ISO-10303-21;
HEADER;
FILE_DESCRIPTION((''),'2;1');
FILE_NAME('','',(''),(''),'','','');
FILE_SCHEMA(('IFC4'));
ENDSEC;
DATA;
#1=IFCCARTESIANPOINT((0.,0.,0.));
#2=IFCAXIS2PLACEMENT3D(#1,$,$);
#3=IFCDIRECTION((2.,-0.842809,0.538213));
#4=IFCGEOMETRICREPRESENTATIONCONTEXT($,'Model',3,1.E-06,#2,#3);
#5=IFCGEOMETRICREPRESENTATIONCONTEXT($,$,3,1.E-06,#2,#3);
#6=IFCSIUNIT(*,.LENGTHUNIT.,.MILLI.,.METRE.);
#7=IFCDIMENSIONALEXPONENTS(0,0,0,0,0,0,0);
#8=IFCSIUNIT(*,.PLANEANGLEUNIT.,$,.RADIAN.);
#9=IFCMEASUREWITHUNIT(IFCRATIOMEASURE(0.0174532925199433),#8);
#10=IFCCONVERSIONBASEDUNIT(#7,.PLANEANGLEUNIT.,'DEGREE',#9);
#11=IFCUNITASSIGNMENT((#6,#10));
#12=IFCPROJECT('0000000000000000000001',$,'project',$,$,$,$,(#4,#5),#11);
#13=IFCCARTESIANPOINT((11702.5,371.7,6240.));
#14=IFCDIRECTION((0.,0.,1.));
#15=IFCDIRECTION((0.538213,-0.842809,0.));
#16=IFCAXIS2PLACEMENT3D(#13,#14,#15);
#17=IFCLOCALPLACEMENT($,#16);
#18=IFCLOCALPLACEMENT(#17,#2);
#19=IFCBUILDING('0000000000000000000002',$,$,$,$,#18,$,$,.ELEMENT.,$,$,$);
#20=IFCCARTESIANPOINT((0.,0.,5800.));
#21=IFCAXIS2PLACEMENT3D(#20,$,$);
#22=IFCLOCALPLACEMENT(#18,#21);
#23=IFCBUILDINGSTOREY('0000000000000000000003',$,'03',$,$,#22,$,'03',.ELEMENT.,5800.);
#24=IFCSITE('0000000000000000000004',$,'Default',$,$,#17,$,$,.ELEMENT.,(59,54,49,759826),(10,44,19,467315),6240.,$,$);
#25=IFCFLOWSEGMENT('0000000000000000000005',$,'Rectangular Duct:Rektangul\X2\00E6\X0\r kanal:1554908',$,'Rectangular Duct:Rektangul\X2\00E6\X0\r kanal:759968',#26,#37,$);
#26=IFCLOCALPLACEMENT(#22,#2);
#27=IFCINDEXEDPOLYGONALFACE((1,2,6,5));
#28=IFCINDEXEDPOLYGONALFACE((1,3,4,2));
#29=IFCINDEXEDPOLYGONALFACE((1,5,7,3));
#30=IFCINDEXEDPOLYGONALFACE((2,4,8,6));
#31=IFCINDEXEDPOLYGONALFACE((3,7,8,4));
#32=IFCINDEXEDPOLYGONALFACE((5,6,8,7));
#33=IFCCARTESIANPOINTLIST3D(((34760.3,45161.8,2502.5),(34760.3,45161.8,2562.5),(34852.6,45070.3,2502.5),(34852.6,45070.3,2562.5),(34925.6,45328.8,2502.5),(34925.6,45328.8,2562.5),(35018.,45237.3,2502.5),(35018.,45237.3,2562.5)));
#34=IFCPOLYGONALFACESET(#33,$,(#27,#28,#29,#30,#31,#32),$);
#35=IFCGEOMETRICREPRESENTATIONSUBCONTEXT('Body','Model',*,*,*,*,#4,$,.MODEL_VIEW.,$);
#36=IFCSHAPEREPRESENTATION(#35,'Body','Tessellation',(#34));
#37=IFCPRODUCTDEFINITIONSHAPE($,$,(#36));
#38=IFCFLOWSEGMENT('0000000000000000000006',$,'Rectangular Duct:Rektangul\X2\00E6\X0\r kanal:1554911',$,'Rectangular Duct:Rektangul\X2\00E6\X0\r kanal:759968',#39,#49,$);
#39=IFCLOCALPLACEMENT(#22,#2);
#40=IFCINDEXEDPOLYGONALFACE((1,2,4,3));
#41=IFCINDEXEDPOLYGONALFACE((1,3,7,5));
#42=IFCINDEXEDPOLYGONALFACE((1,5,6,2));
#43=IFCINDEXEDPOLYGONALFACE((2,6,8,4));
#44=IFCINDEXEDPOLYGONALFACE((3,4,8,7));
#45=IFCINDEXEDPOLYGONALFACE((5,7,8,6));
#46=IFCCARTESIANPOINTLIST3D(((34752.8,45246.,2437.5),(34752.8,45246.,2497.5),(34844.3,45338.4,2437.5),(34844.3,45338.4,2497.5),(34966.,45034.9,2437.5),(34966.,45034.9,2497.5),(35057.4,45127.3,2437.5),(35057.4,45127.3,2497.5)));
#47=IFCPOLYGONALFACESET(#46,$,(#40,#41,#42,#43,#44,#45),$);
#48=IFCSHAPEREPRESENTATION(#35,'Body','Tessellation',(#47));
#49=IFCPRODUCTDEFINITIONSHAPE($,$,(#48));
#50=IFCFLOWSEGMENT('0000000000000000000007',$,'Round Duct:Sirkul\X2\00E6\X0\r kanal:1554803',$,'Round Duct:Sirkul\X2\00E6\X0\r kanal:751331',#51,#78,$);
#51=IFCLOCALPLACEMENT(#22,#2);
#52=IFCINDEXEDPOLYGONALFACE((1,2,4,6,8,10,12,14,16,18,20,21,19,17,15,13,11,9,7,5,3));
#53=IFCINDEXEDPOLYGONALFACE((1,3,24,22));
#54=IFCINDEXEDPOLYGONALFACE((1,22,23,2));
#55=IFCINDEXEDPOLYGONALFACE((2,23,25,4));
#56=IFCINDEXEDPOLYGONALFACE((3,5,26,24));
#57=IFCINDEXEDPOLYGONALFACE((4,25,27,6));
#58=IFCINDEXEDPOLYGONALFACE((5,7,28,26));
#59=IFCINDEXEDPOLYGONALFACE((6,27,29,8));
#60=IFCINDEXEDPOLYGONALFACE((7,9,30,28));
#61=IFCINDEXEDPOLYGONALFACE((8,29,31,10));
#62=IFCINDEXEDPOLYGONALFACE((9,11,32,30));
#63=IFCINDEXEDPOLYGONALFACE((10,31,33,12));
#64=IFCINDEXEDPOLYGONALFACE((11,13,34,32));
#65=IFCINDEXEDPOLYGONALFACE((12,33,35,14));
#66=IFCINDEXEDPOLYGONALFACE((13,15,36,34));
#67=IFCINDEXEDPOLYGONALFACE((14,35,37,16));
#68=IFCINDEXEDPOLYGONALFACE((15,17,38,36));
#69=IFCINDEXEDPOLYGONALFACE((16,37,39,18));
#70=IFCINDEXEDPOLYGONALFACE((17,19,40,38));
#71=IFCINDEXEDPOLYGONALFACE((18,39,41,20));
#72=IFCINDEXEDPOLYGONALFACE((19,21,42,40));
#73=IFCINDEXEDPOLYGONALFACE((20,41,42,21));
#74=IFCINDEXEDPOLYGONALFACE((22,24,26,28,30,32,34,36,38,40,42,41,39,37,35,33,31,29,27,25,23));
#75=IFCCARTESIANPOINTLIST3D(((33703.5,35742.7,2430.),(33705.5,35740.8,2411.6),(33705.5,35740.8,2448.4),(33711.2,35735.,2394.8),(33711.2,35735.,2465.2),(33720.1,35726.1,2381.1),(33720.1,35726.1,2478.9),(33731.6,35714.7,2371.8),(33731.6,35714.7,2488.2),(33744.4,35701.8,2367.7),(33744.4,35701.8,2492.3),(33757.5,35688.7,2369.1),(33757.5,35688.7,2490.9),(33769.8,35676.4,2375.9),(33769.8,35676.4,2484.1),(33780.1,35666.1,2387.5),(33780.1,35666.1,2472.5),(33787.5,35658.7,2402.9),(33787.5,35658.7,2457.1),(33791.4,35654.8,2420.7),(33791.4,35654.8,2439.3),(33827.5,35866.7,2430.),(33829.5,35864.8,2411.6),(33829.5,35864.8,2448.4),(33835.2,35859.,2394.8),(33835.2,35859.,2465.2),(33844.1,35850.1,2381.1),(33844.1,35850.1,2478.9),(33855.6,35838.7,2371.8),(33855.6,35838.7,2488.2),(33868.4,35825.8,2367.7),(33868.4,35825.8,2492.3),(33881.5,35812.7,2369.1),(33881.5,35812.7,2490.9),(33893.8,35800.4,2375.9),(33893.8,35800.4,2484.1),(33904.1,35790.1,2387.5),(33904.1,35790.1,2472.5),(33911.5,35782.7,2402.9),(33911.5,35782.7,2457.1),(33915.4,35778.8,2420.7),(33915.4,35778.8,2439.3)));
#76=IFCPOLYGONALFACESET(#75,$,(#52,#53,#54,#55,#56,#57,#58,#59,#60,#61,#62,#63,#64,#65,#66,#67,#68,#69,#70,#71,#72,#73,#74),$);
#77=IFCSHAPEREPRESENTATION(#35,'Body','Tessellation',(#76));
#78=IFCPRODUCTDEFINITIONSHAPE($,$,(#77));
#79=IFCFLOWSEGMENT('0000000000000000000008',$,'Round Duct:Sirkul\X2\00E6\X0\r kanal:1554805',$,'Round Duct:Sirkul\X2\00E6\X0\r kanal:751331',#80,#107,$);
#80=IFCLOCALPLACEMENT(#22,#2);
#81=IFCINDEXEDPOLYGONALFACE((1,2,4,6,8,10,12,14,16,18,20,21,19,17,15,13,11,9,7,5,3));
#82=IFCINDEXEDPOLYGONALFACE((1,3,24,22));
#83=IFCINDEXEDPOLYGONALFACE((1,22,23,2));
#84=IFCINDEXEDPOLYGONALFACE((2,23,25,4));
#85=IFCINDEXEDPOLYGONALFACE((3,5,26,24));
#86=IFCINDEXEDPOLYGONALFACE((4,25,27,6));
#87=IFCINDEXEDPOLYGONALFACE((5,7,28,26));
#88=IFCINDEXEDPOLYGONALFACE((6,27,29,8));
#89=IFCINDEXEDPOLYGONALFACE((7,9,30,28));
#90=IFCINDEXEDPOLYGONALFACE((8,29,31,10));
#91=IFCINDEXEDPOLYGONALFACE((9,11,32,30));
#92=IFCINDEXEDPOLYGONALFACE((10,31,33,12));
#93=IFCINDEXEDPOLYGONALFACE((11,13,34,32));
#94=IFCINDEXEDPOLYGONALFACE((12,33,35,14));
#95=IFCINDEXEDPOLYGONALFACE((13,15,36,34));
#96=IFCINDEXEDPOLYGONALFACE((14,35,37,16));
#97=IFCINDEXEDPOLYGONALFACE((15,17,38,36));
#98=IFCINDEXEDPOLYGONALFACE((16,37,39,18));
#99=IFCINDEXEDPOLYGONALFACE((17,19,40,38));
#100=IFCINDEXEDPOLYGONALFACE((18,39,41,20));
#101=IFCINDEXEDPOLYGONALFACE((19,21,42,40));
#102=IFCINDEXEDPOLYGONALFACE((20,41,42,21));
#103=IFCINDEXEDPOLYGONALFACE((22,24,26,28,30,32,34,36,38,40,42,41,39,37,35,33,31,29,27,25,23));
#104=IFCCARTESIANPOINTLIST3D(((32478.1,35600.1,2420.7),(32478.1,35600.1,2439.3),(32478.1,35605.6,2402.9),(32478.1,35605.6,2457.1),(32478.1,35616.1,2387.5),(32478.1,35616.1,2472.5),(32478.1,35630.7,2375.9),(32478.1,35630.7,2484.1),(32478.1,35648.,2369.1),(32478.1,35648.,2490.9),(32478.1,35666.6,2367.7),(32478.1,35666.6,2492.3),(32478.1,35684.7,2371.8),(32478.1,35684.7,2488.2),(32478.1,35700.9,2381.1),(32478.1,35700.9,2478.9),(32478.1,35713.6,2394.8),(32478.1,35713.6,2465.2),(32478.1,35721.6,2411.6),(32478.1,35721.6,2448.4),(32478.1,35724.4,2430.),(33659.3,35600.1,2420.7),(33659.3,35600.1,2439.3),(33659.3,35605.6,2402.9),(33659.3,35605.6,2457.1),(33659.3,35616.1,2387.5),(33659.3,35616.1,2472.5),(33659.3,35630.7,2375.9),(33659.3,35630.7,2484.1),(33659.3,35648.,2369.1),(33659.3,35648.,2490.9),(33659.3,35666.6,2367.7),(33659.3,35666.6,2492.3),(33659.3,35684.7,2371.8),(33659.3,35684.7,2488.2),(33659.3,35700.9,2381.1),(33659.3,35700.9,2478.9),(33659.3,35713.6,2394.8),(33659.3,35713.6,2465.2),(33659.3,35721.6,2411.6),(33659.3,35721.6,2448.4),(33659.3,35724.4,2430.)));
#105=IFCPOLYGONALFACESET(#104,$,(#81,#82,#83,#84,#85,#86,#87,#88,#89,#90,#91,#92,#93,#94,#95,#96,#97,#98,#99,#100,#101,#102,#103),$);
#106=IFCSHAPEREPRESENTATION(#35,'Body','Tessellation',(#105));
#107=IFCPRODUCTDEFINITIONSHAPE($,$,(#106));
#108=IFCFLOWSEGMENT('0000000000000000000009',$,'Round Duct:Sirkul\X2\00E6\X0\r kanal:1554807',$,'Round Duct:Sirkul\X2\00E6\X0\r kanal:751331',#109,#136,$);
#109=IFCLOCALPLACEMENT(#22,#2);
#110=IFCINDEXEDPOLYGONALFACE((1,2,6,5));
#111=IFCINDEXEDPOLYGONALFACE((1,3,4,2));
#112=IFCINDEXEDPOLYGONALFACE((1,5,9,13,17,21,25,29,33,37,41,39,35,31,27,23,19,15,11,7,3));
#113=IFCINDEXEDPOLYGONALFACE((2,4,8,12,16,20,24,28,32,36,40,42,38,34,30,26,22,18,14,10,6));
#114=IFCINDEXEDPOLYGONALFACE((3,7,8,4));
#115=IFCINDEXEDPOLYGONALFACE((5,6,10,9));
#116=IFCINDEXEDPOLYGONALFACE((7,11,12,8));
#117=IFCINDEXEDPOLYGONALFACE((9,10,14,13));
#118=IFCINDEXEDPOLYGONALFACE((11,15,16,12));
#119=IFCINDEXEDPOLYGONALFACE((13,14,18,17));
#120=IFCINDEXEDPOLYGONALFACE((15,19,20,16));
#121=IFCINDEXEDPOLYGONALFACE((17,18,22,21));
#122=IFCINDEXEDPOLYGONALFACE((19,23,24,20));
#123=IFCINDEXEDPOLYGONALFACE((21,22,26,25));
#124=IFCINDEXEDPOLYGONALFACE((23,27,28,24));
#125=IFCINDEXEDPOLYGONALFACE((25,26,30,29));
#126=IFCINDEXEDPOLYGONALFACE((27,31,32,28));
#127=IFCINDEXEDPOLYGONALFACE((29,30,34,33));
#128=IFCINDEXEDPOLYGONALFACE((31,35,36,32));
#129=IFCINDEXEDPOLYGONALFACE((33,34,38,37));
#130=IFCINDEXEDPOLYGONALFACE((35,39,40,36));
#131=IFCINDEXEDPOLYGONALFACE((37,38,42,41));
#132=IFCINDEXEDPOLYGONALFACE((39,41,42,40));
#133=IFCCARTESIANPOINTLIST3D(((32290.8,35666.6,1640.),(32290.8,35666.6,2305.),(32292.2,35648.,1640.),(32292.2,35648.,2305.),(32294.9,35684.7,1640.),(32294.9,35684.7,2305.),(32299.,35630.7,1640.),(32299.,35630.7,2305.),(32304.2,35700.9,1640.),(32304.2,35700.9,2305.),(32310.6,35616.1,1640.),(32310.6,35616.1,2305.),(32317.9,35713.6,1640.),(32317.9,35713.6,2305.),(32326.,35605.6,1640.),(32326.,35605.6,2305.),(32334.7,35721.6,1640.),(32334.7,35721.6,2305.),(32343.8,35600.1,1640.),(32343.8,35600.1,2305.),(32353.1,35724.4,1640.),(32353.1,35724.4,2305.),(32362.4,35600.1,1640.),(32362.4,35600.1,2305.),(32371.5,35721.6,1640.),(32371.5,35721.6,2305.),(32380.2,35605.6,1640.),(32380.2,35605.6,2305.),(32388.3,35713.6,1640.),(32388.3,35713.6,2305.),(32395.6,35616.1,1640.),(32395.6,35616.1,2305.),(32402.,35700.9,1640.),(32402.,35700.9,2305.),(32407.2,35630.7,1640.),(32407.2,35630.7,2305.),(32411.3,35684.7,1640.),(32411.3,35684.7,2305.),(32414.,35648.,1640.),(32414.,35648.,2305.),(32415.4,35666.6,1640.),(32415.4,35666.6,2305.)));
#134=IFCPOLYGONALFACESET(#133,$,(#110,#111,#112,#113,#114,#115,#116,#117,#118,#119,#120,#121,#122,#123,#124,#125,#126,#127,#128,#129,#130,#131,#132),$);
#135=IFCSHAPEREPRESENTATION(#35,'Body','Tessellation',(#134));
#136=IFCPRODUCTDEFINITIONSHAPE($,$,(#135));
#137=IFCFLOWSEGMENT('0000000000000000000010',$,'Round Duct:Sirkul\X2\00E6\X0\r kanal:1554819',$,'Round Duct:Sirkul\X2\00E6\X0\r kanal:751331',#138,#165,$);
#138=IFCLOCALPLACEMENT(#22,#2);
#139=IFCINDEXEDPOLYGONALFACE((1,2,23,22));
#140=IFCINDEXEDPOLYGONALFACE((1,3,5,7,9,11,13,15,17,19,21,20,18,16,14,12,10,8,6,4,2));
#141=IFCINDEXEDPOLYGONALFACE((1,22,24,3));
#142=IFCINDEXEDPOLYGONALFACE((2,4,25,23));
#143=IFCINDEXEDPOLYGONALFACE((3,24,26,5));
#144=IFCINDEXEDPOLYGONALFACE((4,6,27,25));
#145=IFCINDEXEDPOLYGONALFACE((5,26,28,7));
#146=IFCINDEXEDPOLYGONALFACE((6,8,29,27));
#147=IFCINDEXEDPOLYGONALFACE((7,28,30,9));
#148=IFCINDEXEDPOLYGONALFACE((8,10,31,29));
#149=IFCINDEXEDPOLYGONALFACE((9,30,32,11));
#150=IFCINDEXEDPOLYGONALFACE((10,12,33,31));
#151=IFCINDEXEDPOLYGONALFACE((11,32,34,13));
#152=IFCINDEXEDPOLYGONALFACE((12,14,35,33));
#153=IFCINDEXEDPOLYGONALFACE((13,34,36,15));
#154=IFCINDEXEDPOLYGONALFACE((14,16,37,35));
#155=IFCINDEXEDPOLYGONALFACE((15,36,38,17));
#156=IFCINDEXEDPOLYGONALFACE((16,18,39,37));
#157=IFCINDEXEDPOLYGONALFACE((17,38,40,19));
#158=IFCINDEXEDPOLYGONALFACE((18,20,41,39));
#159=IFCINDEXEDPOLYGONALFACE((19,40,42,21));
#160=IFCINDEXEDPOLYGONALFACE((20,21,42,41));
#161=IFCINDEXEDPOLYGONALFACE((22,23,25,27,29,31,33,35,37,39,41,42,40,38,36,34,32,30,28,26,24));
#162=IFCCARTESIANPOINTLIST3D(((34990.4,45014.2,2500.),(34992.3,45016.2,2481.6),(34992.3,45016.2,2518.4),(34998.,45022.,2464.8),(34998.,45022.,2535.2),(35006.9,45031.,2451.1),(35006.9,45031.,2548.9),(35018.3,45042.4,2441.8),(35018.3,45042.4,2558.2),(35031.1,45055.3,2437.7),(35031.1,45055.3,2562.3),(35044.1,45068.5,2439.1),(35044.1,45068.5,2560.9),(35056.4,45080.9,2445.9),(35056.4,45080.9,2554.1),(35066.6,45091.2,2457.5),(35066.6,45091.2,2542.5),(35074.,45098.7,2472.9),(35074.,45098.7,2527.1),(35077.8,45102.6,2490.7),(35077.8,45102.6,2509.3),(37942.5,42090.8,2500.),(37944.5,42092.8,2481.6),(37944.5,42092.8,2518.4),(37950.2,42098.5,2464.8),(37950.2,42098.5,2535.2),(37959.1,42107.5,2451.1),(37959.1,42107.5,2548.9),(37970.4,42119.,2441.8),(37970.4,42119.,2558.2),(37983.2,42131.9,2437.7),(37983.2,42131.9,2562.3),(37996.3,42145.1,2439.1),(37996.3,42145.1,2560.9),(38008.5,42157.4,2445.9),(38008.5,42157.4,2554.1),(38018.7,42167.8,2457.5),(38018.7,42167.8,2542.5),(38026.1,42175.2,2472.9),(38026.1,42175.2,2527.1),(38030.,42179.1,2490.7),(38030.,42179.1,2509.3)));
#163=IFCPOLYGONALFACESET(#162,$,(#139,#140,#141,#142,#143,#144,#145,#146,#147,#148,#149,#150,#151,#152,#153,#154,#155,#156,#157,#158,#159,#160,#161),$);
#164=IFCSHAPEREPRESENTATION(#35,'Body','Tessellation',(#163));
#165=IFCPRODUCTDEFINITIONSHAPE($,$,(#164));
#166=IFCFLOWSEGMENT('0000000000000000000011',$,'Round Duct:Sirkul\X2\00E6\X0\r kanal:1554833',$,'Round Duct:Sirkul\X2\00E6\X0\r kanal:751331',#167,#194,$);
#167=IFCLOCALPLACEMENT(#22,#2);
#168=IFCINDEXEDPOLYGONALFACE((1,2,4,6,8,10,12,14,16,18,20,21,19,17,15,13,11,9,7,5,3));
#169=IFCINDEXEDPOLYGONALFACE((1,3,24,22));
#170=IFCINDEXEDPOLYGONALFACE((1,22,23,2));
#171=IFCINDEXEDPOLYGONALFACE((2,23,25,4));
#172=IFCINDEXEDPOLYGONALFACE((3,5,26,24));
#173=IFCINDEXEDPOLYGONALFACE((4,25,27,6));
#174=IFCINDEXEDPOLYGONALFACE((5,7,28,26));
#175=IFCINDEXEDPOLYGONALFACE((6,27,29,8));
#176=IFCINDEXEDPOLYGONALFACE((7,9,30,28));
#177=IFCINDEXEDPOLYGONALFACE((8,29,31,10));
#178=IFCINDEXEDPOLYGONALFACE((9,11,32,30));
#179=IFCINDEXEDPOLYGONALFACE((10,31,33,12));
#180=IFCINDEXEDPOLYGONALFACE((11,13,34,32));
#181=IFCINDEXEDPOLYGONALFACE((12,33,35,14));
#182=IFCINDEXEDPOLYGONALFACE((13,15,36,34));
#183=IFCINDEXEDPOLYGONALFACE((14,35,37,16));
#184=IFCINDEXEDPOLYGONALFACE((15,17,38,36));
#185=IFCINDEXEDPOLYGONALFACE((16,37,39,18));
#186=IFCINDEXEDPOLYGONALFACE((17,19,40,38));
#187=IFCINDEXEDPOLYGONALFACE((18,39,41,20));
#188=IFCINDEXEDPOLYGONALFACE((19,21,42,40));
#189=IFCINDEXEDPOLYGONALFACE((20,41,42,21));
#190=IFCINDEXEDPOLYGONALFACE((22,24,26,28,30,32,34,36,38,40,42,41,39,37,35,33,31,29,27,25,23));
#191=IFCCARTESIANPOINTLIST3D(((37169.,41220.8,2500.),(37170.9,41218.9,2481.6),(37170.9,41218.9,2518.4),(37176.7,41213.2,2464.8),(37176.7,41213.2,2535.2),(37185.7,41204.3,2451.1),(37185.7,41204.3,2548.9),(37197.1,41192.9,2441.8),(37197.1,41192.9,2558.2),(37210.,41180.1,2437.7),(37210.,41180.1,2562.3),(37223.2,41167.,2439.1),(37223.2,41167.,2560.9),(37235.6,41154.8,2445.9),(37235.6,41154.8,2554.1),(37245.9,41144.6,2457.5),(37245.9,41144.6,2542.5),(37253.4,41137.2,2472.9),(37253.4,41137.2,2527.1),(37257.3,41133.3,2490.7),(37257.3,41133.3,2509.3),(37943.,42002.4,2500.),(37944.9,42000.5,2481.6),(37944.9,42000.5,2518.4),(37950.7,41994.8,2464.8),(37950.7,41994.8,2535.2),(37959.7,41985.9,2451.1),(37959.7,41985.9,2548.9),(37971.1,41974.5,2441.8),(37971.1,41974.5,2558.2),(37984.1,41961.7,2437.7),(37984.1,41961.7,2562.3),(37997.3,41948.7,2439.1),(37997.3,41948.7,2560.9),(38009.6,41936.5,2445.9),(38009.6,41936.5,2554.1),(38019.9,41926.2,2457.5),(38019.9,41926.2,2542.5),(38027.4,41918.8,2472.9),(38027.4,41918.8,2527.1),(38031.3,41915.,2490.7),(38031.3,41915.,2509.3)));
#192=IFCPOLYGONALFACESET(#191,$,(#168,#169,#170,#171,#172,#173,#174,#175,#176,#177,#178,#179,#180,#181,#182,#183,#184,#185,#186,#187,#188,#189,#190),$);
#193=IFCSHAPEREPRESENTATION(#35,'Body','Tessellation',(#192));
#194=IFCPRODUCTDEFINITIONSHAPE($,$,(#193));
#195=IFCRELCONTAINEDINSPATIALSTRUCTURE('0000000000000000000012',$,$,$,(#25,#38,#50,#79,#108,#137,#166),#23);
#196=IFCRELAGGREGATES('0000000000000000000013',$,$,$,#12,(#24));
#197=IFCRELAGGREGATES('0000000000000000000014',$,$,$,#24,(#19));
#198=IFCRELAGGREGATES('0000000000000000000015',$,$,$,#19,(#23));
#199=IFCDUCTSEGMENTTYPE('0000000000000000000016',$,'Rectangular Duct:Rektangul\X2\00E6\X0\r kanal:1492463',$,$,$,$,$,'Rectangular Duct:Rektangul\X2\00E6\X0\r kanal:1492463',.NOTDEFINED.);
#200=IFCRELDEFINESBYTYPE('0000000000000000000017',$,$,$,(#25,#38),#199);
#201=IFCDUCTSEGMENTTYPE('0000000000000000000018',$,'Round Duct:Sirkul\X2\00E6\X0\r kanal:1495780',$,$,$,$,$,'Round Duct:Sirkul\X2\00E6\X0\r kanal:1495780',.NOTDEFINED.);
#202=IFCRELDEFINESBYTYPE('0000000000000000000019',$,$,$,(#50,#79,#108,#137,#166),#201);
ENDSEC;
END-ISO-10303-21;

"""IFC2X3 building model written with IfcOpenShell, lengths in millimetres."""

from ifc_helpers import new_model, entity, si_unit, converted_unit, direction, frame, frame_2d, origin, origin_2d_with_axis, place, context, subcontext, project, spatial, rectangle, circle, extrude, type_object, element, save


model = new_model("IFC2X3")

# Units and contexts
model_context = context("Model", 3, precision=1e-06, world=origin(), true_north=direction((2.0, -0.842809, 0.538213)))
context_of_model = context(None, 3, precision=1e-06, world=origin(), true_north=direction((2.0, -0.842809, 0.538213)))
body_context = subcontext(model_context, "Body", "Model", "MODEL_VIEW")
ifc_project = project(units=[si_unit("LENGTHUNIT", "METRE", prefix="MILLI"), converted_unit("PLANEANGLEUNIT", "DEGREE", entity("IfcRatioMeasure", 0.0174532925199433), si_unit("PLANEANGLEUNIT", "RADIAN"), dimensions=[0, 0, 0, 0, 0, 0, 0])], contexts=[model_context, context_of_model])

# Site, building, storey
site_placement = place(None, frame((11702.5, 371.7, 6240.0), z_axis=(0.0, 0.0, 1.0), x_axis=(0.538213, -0.842809, 0.0)))
site = spatial("IfcSite", under=ifc_project, at=site_placement, Name="Default", CompositionType="ELEMENT", RefLatitude=(59, 54, 49, 759826), RefLongitude=(10, 44, 19, 467315), RefElevation=6240.0)
building_placement = place(site_placement, origin())
building = spatial("IfcBuilding", under=site, at=building_placement, CompositionType="ELEMENT")
storey_placement = place(building_placement, frame((0.0, 0.0, 5800.0)))
storey = spatial("IfcBuildingStorey", under=building, at=storey_placement, Name="03", LongName="03", CompositionType="ELEMENT", Elevation=5800.0)

# Flow segments
duct_segment_type_1 = type_object("IfcDuctSegmentType", Name="Rectangular Duct:Rektangulær kanal:1492463", ElementType="Rectangular Duct:Rektangulær kanal:1492463", PredefinedType="NOTDEFINED")
flow_segment_1_placement = place(storey_placement, origin())
element("IfcFlowSegment", 1, at=flow_segment_1_placement, inside=storey, type_object=duct_segment_type_1, Name="Rectangular Duct:Rektangulær kanal:1554908", ObjectType="Rectangular Duct:Rektangulær kanal:759968", context=body_context, shape_type="SweptSolid", body=[
    extrude(rectangle(XDim=235.0, YDim=130.0, at=frame_2d((0.0, 0.0), x_axis=(1.0, 0.0))), frame((34889.1, 45199.5, 2502.5), z_axis=(0.0, 0.0, 1.0), x_axis=(0.703643, 0.710554, 0.0)), (0.0, 0.0, 1.0), 60.0),
])
flow_segment_2_placement = place(storey_placement, origin())
element("IfcFlowSegment", 2, at=flow_segment_2_placement, inside=storey, type_object=duct_segment_type_1, Name="Rectangular Duct:Rektangulær kanal:1554911", ObjectType="Rectangular Duct:Rektangulær kanal:759968", context=body_context, shape_type="SweptSolid", body=[
    extrude(rectangle(XDim=300.0, YDim=130.0, at=frame_2d((0.0, 0.0), x_axis=(1.0, 0.0))), frame((34905.1, 45186.6, 2437.5), z_axis=(0.0, 0.0, 1.0), x_axis=(0.710554, -0.703643, 0.0)), (0.0, 0.0, 1.0), 60.0),
])
duct_segment_type_2 = type_object("IfcDuctSegmentType", Name="Round Duct:Sirkulær kanal:1495780", ElementType="Round Duct:Sirkulær kanal:1495780", PredefinedType="NOTDEFINED")
flow_segment_3_placement = place(storey_placement, origin())
element("IfcFlowSegment", 3, at=flow_segment_3_placement, inside=storey, type_object=duct_segment_type_2, Name="Round Duct:Sirkulær kanal:1554803", ObjectType="Round Duct:Sirkulær kanal:751331", context=body_context, shape_type="SweptSolid", body=[
    extrude(circle(Radius=62.5, at=origin_2d_with_axis()), frame((33747.7, 35698.5, 2430.0), z_axis=(0.707107, 0.707107, 0.0), x_axis=(-0.707107, 0.707107, 0.0)), (0.0, 0.0, 1.0), 175.4),
])
flow_segment_4_placement = place(storey_placement, origin())
element("IfcFlowSegment", 4, at=flow_segment_4_placement, inside=storey, type_object=duct_segment_type_2, Name="Round Duct:Sirkulær kanal:1554805", ObjectType="Round Duct:Sirkulær kanal:751331", context=body_context, shape_type="SweptSolid", body=[
    extrude(circle(Radius=62.5, at=frame_2d((0.0, 0.0), x_axis=(1.0, 0.0))), frame((32478.1, 35661.9, 2430.0), z_axis=(1.0, 0.0, 0.0), x_axis=(0.0, 1.0, 0.0)), (0.0, 0.0, 1.0), 1181.2),
])
flow_segment_5_placement = place(storey_placement, origin())
element("IfcFlowSegment", 5, at=flow_segment_5_placement, inside=storey, type_object=duct_segment_type_2, Name="Round Duct:Sirkulær kanal:1554807", ObjectType="Round Duct:Sirkulær kanal:751331", context=body_context, shape_type="SweptSolid", body=[
    extrude(circle(Radius=62.5, at=frame_2d((0.0, 0.0), x_axis=(1.0, 0.0))), frame((32353.1, 35661.9, 1640.0), z_axis=(0.0, 0.0, 1.0), x_axis=(0.0, 1.0, 0.0)), (0.0, 0.0, 1.0), 665.0),
])
flow_segment_6_placement = place(storey_placement, origin())
element("IfcFlowSegment", 6, at=flow_segment_6_placement, inside=storey, type_object=duct_segment_type_2, Name="Round Duct:Sirkulær kanal:1554819", ObjectType="Round Duct:Sirkulær kanal:751331", context=body_context, shape_type="SweptSolid", body=[
    extrude(circle(Radius=62.5, at=origin_2d_with_axis()), frame((35034.4, 45058.6, 2500.0), z_axis=(0.710554, -0.703643, 0.0), x_axis=(-0.703643, -0.710554, 0.0)), (0.0, 0.0, 1.0), 4154.7),
])
flow_segment_7_placement = place(storey_placement, origin())
element("IfcFlowSegment", 7, at=flow_segment_7_placement, inside=storey, type_object=duct_segment_type_2, Name="Round Duct:Sirkulær kanal:1554833", ObjectType="Round Duct:Sirkulær kanal:751331", context=body_context, shape_type="SweptSolid", body=[
    extrude(circle(Radius=62.5, at=frame_2d((0.0, 0.0), x_axis=(1.0, 0.0))), frame((37213.4, 41176.8, 2500.0), z_axis=(0.703643, 0.710554, 0.0), x_axis=(-0.710554, 0.703643, 0.0)), (0.0, 0.0, 1.0), 1100.0),
])

save(model, "model.ifc")
